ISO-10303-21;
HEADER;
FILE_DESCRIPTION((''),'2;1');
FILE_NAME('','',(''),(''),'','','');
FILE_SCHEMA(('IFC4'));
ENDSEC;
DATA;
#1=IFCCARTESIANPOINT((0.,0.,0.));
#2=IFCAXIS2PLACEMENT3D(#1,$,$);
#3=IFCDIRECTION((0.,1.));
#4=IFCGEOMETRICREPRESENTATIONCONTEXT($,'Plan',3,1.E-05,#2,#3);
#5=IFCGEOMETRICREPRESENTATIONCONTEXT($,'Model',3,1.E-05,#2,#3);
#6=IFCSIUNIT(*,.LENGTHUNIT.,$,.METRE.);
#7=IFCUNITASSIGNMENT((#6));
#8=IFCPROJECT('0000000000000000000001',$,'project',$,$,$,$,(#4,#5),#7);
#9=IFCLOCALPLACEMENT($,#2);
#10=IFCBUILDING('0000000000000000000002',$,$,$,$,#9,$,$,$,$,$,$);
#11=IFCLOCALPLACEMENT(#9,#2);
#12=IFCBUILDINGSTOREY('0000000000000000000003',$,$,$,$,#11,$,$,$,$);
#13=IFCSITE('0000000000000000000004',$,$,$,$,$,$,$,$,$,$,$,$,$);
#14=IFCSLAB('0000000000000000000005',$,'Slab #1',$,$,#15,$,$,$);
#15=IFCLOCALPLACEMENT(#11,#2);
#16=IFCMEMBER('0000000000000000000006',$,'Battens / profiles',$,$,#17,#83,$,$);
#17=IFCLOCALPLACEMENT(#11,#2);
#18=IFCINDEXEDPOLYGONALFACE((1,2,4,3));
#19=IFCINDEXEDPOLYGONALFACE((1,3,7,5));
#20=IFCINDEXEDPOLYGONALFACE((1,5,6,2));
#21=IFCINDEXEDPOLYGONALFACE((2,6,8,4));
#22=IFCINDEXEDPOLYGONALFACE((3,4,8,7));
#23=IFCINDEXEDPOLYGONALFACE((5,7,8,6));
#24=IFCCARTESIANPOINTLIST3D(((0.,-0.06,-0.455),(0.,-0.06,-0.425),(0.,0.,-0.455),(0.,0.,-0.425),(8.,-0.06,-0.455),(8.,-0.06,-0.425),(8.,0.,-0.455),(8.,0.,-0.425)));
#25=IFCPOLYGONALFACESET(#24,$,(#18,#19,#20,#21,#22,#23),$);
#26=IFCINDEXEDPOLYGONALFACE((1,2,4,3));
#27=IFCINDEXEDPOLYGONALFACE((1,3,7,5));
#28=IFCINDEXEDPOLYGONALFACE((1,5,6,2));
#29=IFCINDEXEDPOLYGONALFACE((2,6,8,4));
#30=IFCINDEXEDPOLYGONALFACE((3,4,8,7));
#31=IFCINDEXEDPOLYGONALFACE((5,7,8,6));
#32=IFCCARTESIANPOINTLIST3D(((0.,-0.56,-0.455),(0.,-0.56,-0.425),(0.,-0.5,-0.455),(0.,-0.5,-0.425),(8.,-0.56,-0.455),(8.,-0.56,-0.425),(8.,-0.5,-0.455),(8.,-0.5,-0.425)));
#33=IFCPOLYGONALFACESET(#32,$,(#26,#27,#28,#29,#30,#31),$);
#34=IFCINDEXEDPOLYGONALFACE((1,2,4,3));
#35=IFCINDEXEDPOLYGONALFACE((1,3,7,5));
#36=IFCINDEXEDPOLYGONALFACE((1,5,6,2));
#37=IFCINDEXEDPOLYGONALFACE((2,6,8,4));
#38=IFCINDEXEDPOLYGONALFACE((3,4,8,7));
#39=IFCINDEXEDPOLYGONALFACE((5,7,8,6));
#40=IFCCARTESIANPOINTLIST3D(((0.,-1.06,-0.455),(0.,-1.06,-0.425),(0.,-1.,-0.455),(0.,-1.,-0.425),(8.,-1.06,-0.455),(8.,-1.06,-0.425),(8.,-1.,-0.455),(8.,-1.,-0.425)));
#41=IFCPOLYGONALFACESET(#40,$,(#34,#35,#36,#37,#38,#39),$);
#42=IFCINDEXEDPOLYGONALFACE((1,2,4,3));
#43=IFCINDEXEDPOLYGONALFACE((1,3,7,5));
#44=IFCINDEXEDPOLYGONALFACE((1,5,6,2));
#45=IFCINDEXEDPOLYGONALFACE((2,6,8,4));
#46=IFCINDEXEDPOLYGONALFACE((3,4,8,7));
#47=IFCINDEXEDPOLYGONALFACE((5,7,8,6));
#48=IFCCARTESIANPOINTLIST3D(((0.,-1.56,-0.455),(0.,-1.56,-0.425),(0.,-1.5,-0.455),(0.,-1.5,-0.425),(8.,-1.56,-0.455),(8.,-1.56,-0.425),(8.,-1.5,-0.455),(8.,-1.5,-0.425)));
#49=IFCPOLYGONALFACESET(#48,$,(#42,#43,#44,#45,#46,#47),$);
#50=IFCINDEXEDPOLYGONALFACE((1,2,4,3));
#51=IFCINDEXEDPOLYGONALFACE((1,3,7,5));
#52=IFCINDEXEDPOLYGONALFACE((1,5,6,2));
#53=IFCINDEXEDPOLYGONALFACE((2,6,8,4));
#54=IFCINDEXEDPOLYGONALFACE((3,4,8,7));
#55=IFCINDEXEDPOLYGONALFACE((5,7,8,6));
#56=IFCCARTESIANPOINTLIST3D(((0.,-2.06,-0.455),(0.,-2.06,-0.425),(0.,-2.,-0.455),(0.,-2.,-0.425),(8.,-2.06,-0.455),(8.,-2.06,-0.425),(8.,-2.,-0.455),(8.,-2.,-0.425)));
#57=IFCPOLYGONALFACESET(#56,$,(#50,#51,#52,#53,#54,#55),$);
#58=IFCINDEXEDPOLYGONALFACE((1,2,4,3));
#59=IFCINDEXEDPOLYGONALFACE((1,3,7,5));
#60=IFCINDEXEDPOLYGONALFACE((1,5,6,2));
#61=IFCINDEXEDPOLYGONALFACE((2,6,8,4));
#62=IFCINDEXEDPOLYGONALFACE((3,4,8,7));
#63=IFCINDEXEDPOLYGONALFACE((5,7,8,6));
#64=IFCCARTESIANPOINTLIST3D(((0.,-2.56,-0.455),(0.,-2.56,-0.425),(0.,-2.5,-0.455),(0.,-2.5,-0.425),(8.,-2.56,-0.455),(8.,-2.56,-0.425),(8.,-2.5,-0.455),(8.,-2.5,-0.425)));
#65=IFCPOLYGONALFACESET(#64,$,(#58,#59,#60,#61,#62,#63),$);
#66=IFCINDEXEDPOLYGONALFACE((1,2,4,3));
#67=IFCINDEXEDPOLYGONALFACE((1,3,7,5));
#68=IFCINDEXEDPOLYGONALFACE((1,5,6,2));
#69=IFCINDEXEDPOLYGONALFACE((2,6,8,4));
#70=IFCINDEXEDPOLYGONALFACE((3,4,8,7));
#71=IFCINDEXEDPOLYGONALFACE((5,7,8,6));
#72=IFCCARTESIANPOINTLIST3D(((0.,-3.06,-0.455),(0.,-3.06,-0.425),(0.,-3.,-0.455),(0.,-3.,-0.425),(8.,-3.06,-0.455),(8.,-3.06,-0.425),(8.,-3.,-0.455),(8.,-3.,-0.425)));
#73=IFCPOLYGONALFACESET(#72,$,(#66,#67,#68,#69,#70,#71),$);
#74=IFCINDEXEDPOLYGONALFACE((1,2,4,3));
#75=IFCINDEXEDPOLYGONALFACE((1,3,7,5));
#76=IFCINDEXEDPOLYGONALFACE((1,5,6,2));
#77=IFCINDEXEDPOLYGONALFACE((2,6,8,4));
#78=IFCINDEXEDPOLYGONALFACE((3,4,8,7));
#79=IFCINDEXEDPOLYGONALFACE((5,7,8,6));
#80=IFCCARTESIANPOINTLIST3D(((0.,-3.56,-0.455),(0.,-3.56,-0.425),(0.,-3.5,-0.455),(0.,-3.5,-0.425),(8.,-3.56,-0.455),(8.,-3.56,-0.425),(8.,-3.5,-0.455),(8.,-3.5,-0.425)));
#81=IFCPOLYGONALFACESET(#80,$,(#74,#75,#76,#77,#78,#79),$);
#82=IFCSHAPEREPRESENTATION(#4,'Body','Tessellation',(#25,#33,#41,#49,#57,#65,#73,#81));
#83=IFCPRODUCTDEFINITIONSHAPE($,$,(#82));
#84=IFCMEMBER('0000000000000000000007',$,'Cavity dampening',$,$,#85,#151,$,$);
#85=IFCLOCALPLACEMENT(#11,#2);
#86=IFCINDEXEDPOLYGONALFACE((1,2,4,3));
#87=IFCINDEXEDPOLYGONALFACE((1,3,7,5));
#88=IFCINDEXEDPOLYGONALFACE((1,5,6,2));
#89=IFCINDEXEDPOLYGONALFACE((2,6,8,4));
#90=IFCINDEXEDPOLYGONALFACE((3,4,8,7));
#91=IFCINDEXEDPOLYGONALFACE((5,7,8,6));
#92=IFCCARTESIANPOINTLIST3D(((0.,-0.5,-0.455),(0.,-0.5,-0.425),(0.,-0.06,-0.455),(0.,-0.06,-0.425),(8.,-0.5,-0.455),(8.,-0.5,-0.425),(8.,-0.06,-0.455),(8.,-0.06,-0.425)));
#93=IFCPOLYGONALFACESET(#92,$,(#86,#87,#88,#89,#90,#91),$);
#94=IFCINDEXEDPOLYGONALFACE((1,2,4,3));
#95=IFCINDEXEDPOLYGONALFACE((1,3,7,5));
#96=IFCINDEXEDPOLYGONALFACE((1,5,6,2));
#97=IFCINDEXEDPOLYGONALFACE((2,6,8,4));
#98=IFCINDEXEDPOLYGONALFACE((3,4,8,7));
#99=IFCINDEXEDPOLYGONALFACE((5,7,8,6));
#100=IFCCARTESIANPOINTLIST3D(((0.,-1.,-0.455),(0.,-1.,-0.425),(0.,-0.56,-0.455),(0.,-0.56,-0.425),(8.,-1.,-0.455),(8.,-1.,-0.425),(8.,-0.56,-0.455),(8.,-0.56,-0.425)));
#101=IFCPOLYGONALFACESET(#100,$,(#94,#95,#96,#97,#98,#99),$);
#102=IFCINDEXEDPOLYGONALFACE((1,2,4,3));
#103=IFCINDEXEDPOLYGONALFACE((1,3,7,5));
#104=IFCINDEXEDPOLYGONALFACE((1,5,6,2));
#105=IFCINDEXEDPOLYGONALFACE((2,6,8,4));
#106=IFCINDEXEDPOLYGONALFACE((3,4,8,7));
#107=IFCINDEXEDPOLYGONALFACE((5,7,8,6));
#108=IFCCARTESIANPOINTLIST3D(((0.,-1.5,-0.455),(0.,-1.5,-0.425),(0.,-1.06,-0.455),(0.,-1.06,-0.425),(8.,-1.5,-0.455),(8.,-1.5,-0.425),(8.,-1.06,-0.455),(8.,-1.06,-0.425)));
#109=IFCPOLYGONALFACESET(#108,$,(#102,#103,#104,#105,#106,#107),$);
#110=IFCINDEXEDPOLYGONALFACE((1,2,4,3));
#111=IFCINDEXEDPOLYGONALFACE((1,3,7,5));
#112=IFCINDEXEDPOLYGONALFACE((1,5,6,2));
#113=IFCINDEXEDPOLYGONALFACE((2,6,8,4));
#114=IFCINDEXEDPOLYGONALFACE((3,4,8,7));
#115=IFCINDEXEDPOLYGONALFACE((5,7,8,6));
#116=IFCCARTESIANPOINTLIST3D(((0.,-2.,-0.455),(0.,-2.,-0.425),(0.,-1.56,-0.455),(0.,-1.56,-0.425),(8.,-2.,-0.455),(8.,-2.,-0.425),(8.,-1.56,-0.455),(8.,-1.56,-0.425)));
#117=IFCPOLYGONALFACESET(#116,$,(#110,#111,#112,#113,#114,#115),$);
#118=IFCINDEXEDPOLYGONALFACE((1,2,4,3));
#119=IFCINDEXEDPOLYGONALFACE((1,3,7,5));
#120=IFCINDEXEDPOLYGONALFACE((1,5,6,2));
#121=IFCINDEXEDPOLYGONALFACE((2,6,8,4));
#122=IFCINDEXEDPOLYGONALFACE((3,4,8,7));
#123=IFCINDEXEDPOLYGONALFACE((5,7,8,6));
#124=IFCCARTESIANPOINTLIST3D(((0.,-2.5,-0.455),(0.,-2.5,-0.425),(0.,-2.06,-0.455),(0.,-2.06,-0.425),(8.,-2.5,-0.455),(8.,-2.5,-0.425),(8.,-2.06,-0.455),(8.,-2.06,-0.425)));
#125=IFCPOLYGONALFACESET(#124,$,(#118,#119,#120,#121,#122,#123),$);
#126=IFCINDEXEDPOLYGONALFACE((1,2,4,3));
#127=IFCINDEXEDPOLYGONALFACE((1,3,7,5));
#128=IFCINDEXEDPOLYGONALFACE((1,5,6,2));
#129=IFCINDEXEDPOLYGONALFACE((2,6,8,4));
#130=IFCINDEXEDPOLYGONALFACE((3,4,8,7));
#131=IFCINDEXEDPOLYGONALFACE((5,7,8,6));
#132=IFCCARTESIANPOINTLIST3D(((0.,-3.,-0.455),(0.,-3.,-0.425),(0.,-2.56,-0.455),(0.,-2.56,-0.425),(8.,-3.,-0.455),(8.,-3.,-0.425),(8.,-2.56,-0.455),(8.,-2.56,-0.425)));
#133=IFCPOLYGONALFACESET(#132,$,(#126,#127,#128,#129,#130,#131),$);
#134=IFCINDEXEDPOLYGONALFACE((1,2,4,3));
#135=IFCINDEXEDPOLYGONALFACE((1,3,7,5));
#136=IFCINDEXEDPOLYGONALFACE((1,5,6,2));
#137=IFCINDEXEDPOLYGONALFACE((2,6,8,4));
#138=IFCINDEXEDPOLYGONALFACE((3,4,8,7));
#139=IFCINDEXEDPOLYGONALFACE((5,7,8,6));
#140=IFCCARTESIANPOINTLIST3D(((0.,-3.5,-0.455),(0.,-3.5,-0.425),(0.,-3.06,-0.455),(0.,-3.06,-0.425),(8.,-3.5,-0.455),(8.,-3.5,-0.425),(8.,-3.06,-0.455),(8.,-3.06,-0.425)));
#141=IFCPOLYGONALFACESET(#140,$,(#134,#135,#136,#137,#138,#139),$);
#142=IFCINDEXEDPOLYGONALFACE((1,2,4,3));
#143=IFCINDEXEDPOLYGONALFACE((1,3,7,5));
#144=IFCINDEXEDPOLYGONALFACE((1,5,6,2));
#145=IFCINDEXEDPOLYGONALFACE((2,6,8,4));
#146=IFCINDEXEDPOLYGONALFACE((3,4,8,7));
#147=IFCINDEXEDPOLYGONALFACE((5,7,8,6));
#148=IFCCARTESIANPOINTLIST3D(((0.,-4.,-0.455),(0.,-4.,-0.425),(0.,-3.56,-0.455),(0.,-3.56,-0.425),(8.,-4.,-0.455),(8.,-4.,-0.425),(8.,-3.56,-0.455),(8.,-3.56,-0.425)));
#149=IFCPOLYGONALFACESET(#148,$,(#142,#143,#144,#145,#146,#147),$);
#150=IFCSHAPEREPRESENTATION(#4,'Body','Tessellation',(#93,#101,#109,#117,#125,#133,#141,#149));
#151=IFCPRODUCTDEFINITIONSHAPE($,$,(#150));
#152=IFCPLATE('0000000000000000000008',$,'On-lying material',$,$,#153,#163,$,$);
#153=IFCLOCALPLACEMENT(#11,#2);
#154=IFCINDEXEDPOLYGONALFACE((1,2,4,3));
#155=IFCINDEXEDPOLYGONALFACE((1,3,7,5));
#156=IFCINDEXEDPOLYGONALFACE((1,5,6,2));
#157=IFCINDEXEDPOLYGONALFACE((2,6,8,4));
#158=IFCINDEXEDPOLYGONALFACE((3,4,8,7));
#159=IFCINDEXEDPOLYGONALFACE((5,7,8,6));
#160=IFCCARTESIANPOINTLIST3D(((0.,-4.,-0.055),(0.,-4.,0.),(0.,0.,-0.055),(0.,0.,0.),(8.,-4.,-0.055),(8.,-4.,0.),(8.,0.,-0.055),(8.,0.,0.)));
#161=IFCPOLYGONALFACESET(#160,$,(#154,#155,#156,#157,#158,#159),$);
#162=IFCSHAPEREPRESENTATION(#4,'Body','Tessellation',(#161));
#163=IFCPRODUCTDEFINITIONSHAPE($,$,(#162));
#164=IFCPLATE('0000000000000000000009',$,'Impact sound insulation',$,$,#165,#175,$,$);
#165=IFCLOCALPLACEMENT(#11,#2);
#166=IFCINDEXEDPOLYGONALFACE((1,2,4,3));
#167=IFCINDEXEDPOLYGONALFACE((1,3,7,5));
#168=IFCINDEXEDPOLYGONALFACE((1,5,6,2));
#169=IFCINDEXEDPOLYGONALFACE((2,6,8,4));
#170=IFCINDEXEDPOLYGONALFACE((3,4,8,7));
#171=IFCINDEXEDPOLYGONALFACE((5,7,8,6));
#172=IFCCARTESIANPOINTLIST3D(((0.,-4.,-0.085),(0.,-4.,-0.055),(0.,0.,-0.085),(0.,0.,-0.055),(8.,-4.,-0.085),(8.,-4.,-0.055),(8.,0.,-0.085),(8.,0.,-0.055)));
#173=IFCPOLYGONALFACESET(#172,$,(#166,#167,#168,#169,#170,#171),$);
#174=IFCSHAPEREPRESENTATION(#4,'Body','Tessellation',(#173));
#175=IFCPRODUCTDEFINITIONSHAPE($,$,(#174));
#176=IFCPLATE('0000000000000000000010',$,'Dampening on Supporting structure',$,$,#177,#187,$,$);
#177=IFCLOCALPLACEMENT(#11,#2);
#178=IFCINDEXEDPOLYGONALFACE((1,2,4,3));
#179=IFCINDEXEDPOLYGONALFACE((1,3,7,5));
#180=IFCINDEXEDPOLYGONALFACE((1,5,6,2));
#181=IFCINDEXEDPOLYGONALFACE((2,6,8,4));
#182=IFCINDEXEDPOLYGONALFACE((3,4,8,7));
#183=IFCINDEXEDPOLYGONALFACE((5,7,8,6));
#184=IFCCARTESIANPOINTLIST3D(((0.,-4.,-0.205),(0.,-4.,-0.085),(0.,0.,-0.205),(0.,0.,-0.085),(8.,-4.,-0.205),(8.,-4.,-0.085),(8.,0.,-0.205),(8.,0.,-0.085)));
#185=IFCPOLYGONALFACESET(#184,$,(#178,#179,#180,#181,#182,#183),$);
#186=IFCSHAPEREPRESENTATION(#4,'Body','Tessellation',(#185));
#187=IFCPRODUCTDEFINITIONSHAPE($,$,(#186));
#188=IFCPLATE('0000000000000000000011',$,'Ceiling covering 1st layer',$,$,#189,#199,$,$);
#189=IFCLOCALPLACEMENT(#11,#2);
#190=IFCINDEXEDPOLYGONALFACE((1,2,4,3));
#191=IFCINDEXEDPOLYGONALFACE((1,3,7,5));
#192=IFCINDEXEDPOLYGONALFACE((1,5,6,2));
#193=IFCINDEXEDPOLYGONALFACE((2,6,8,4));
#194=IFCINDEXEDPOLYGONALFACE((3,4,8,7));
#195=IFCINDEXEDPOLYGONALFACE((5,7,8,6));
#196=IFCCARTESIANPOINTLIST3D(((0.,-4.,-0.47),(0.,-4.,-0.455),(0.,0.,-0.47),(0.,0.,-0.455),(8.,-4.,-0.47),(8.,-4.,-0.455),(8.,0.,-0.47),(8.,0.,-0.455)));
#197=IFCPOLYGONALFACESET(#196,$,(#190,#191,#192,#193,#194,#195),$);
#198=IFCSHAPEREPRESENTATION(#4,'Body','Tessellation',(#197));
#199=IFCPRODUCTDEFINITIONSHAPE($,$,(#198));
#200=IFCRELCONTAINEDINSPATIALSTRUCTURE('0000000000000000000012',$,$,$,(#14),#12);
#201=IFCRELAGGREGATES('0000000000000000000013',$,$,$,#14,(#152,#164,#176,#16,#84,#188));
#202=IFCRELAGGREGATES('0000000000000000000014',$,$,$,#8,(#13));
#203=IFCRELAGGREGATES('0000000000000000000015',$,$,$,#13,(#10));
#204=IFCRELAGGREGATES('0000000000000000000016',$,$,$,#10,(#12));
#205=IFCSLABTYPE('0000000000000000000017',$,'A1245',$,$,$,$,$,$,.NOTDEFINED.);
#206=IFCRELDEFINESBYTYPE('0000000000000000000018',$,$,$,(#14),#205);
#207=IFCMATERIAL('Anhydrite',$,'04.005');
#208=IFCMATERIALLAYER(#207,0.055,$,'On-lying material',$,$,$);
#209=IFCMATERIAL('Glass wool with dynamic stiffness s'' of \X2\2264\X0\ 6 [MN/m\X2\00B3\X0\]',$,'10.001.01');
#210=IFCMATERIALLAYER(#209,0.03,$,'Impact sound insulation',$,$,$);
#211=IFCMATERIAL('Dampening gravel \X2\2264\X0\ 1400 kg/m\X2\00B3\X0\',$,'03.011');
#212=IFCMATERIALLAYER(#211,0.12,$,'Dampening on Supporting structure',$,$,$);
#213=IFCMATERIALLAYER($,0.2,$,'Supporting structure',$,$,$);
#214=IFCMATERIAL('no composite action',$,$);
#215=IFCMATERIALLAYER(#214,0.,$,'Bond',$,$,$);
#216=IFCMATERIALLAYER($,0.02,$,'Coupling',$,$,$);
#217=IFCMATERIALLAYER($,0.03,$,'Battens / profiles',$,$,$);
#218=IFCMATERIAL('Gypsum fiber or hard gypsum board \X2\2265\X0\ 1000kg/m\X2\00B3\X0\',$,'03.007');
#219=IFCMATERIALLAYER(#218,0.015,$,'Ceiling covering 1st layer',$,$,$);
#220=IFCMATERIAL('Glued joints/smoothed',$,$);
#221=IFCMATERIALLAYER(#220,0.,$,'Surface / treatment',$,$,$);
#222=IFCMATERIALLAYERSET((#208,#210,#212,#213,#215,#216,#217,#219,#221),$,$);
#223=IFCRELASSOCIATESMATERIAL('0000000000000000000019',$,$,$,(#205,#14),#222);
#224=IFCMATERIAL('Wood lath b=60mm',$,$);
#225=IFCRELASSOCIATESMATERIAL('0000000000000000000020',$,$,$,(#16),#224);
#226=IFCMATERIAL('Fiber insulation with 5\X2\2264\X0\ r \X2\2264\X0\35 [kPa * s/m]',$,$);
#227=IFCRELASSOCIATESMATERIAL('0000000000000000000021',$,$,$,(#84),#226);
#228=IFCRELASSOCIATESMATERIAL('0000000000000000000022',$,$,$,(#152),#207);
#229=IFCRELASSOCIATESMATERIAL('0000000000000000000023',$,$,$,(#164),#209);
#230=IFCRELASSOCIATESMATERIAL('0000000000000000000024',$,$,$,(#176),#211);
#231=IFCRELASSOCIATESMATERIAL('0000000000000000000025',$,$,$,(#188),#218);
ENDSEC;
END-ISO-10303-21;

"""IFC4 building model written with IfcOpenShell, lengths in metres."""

from ifc_helpers import new_model, si_unit, direction, frame, frame_2d, origin, origin_with_axes, place, context, project, spatial, rectangle, extrude, material, layer, layer_set, type_object, element, aggregate, save


model = new_model("IFC4")

# Units and contexts
plan_context = context("Plan", 3, precision=1e-05, world=origin(), true_north=direction((0.0, 1.0)))
model_context = context("Model", 3, precision=1e-05, world=origin(), true_north=direction((0.0, 1.0)))
ifc_project = project(units=[si_unit("LENGTHUNIT", "METRE")], contexts=[plan_context, model_context])

# Site, building, storey
site = spatial("IfcSite", under=ifc_project)
building_placement = place(None, origin())
building = spatial("IfcBuilding", under=site, at=building_placement)
storey_placement = place(building_placement, origin())
storey = spatial("IfcBuildingStorey", under=building, at=storey_placement)

# Slab, members, plates
ifc_material_1 = material(Name="Anhydrite", Category="04.005")
ifc_layer_1 = layer(ifc_material_1, 0.055, Name="On-lying material")
ifc_material_2 = material(Name="Glass wool with dynamic stiffness s' of ≤ 6 [MN/m³]", Category="10.001.01")
ifc_layer_2 = layer(ifc_material_2, 0.03, Name="Impact sound insulation")
ifc_material_3 = material(Name="Dampening gravel ≤ 1400 kg/m³", Category="03.011")
ifc_layer_3 = layer(ifc_material_3, 0.12, Name="Dampening on Supporting structure")
ifc_layer_4 = layer(None, 0.2, Name="Supporting structure")
ifc_material_4 = material(Name="no composite action")
ifc_layer_5 = layer(ifc_material_4, 0.0, Name="Bond")
ifc_layer_6 = layer(None, 0.02, Name="Coupling")
ifc_layer_7 = layer(None, 0.03, Name="Battens / profiles")
ifc_material_5 = material(Name="Gypsum fiber or hard gypsum board ≥ 1000kg/m³", Category="03.007")
ifc_layer_8 = layer(ifc_material_5, 0.015, Name="Ceiling covering 1st layer")
ifc_material_6 = material(Name="Glued joints/smoothed")
ifc_layer_9 = layer(ifc_material_6, 0.0, Name="Surface / treatment")
ifc_layer_set = layer_set([ifc_layer_1, ifc_layer_2, ifc_layer_3, ifc_layer_4, ifc_layer_5, ifc_layer_6, ifc_layer_7, ifc_layer_8, ifc_layer_9])
slab_type = type_object("IfcSlabType", Name="A1245", PredefinedType="NOTDEFINED", material=ifc_layer_set)
slab_placement = place(None, frame((0.0, 0.0, 0.0), z_axis=(0.0, 0.0, -1.0), x_axis=(1.0, 0.0, 0.0)))
slab = element("IfcSlab", 1, at=slab_placement, inside=storey, type_object=slab_type, material=ifc_layer_set, Name="Slab #1")
ifc_material_7 = material(Name="Wood lath b=60mm")
member_1_placement = place(slab_placement, origin())
member_1 = element("IfcMember", 2, at=member_1_placement, material=ifc_material_7, Name="Battens / profiles", context=plan_context, shape_type="SweptSolid", body=[
    extrude(rectangle(XDim=0.06, YDim=0.03, at=frame_2d((0.03, 0.015), x_axis=(1.0, 0.0))), frame((0.0, 0.0, 0.425), z_axis=(1.0, 0.0, 0.0), x_axis=(0.0, 1.0, 0.0)), (0.0, 0.0, 1.0), 8.0),
    extrude(rectangle(XDim=0.06, YDim=0.03, at=frame_2d((0.03, 0.015), x_axis=(1.0, 0.0))), frame((0.0, 0.5, 0.425), z_axis=(1.0, 0.0, 0.0), x_axis=(0.0, 1.0, 0.0)), (0.0, 0.0, 1.0), 8.0),
    extrude(rectangle(XDim=0.06, YDim=0.03, at=frame_2d((0.03, 0.015), x_axis=(1.0, 0.0))), frame((0.0, 1.0, 0.425), z_axis=(1.0, 0.0, 0.0), x_axis=(0.0, 1.0, 0.0)), (0.0, 0.0, 1.0), 8.0),
    extrude(rectangle(XDim=0.06, YDim=0.03, at=frame_2d((0.03, 0.015), x_axis=(1.0, 0.0))), frame((0.0, 1.5, 0.425), z_axis=(1.0, 0.0, 0.0), x_axis=(0.0, 1.0, 0.0)), (0.0, 0.0, 1.0), 8.0),
    extrude(rectangle(XDim=0.06, YDim=0.03, at=frame_2d((0.03, 0.015), x_axis=(1.0, 0.0))), frame((0.0, 2.0, 0.425), z_axis=(1.0, 0.0, 0.0), x_axis=(0.0, 1.0, 0.0)), (0.0, 0.0, 1.0), 8.0),
    extrude(rectangle(XDim=0.06, YDim=0.03, at=frame_2d((0.03, 0.015), x_axis=(1.0, 0.0))), frame((0.0, 2.5, 0.425), z_axis=(1.0, 0.0, 0.0), x_axis=(0.0, 1.0, 0.0)), (0.0, 0.0, 1.0), 8.0),
    extrude(rectangle(XDim=0.06, YDim=0.03, at=frame_2d((0.03, 0.015), x_axis=(1.0, 0.0))), frame((0.0, 3.0, 0.425), z_axis=(1.0, 0.0, 0.0), x_axis=(0.0, 1.0, 0.0)), (0.0, 0.0, 1.0), 8.0),
    extrude(rectangle(XDim=0.06, YDim=0.03, at=frame_2d((0.03, 0.015), x_axis=(1.0, 0.0))), frame((0.0, 3.5, 0.425), z_axis=(1.0, 0.0, 0.0), x_axis=(0.0, 1.0, 0.0)), (0.0, 0.0, 1.0), 8.0),
])
ifc_material_8 = material(Name="Fiber insulation with 5≤ r ≤35 [kPa * s/m]")
member_2_placement = place(slab_placement, origin())
member_2 = element("IfcMember", 3, at=member_2_placement, material=ifc_material_8, Name="Cavity dampening", context=plan_context, shape_type="SweptSolid", body=[
    extrude(rectangle(XDim=0.44, YDim=0.03, at=frame_2d((0.22, 0.015), x_axis=(1.0, 0.0))), frame((0.0, 0.06, 0.425), z_axis=(1.0, 0.0, 0.0), x_axis=(0.0, 1.0, 0.0)), (0.0, 0.0, 1.0), 8.0),
    extrude(rectangle(XDim=0.44, YDim=0.03, at=frame_2d((0.22, 0.015), x_axis=(1.0, 0.0))), frame((0.0, 0.56, 0.425), z_axis=(1.0, 0.0, 0.0), x_axis=(0.0, 1.0, 0.0)), (0.0, 0.0, 1.0), 8.0),
    extrude(rectangle(XDim=0.44, YDim=0.03, at=frame_2d((0.22, 0.015), x_axis=(1.0, 0.0))), frame((0.0, 1.06, 0.425), z_axis=(1.0, 0.0, 0.0), x_axis=(0.0, 1.0, 0.0)), (0.0, 0.0, 1.0), 8.0),
    extrude(rectangle(XDim=0.44, YDim=0.03, at=frame_2d((0.22, 0.015), x_axis=(1.0, 0.0))), frame((0.0, 1.56, 0.425), z_axis=(1.0, 0.0, 0.0), x_axis=(0.0, 1.0, 0.0)), (0.0, 0.0, 1.0), 8.0),
    extrude(rectangle(XDim=0.44, YDim=0.03, at=frame_2d((0.22, 0.015), x_axis=(1.0, 0.0))), frame((0.0, 2.06, 0.425), z_axis=(1.0, 0.0, 0.0), x_axis=(0.0, 1.0, 0.0)), (0.0, 0.0, 1.0), 8.0),
    extrude(rectangle(XDim=0.44, YDim=0.03, at=frame_2d((0.22, 0.015), x_axis=(1.0, 0.0))), frame((0.0, 2.56, 0.425), z_axis=(1.0, 0.0, 0.0), x_axis=(0.0, 1.0, 0.0)), (0.0, 0.0, 1.0), 8.0),
    extrude(rectangle(XDim=0.44, YDim=0.03, at=frame_2d((0.22, 0.015), x_axis=(1.0, 0.0))), frame((0.0, 3.06, 0.425), z_axis=(1.0, 0.0, 0.0), x_axis=(0.0, 1.0, 0.0)), (0.0, 0.0, 1.0), 8.0),
    extrude(rectangle(XDim=0.44, YDim=0.03, at=frame_2d((0.22, 0.015), x_axis=(1.0, 0.0))), frame((0.0, 3.56, 0.425), z_axis=(1.0, 0.0, 0.0), x_axis=(0.0, 1.0, 0.0)), (0.0, 0.0, 1.0), 8.0),
])
plate_1_placement = place(slab_placement, origin())
plate_1 = element("IfcPlate", 4, at=plate_1_placement, material=ifc_material_1, Name="On-lying material", context=plan_context, shape_type="SweptSolid", body=[
    extrude(rectangle(XDim=8.0, YDim=4.0, at=frame_2d((4.0, 2.0), x_axis=(1.0, 0.0))), origin_with_axes(), (0.0, 0.0, 1.0), 0.055),
])
plate_2_placement = place(slab_placement, origin())
plate_2 = element("IfcPlate", 5, at=plate_2_placement, material=ifc_material_2, Name="Impact sound insulation", context=plan_context, shape_type="SweptSolid", body=[
    extrude(rectangle(XDim=8.0, YDim=4.0, at=frame_2d((4.0, 2.0), x_axis=(1.0, 0.0))), frame((0.0, 0.0, 0.055), z_axis=(0.0, 0.0, 1.0), x_axis=(1.0, 0.0, 0.0)), (0.0, 0.0, 1.0), 0.03),
])
plate_3_placement = place(slab_placement, origin())
plate_3 = element("IfcPlate", 6, at=plate_3_placement, material=ifc_material_3, Name="Dampening on Supporting structure", context=plan_context, shape_type="SweptSolid", body=[
    extrude(rectangle(XDim=8.0, YDim=4.0, at=frame_2d((4.0, 2.0), x_axis=(1.0, 0.0))), frame((0.0, 0.0, 0.085), z_axis=(0.0, 0.0, 1.0), x_axis=(1.0, 0.0, 0.0)), (0.0, 0.0, 1.0), 0.12),
])
plate_4_placement = place(slab_placement, origin())
plate_4 = element("IfcPlate", 7, at=plate_4_placement, material=ifc_material_5, Name="Ceiling covering 1st layer", context=plan_context, shape_type="SweptSolid", body=[
    extrude(rectangle(XDim=8.0, YDim=4.0, at=frame_2d((4.0, 2.0), x_axis=(1.0, 0.0))), frame((0.0, 0.0, 0.455), z_axis=(0.0, 0.0, 1.0), x_axis=(1.0, 0.0, 0.0)), (0.0, 0.0, 1.0), 0.015),
])
aggregate(slab, [plate_1, plate_2, plate_3, member_1, member_2, plate_4])

save(model, "model.ifc")
